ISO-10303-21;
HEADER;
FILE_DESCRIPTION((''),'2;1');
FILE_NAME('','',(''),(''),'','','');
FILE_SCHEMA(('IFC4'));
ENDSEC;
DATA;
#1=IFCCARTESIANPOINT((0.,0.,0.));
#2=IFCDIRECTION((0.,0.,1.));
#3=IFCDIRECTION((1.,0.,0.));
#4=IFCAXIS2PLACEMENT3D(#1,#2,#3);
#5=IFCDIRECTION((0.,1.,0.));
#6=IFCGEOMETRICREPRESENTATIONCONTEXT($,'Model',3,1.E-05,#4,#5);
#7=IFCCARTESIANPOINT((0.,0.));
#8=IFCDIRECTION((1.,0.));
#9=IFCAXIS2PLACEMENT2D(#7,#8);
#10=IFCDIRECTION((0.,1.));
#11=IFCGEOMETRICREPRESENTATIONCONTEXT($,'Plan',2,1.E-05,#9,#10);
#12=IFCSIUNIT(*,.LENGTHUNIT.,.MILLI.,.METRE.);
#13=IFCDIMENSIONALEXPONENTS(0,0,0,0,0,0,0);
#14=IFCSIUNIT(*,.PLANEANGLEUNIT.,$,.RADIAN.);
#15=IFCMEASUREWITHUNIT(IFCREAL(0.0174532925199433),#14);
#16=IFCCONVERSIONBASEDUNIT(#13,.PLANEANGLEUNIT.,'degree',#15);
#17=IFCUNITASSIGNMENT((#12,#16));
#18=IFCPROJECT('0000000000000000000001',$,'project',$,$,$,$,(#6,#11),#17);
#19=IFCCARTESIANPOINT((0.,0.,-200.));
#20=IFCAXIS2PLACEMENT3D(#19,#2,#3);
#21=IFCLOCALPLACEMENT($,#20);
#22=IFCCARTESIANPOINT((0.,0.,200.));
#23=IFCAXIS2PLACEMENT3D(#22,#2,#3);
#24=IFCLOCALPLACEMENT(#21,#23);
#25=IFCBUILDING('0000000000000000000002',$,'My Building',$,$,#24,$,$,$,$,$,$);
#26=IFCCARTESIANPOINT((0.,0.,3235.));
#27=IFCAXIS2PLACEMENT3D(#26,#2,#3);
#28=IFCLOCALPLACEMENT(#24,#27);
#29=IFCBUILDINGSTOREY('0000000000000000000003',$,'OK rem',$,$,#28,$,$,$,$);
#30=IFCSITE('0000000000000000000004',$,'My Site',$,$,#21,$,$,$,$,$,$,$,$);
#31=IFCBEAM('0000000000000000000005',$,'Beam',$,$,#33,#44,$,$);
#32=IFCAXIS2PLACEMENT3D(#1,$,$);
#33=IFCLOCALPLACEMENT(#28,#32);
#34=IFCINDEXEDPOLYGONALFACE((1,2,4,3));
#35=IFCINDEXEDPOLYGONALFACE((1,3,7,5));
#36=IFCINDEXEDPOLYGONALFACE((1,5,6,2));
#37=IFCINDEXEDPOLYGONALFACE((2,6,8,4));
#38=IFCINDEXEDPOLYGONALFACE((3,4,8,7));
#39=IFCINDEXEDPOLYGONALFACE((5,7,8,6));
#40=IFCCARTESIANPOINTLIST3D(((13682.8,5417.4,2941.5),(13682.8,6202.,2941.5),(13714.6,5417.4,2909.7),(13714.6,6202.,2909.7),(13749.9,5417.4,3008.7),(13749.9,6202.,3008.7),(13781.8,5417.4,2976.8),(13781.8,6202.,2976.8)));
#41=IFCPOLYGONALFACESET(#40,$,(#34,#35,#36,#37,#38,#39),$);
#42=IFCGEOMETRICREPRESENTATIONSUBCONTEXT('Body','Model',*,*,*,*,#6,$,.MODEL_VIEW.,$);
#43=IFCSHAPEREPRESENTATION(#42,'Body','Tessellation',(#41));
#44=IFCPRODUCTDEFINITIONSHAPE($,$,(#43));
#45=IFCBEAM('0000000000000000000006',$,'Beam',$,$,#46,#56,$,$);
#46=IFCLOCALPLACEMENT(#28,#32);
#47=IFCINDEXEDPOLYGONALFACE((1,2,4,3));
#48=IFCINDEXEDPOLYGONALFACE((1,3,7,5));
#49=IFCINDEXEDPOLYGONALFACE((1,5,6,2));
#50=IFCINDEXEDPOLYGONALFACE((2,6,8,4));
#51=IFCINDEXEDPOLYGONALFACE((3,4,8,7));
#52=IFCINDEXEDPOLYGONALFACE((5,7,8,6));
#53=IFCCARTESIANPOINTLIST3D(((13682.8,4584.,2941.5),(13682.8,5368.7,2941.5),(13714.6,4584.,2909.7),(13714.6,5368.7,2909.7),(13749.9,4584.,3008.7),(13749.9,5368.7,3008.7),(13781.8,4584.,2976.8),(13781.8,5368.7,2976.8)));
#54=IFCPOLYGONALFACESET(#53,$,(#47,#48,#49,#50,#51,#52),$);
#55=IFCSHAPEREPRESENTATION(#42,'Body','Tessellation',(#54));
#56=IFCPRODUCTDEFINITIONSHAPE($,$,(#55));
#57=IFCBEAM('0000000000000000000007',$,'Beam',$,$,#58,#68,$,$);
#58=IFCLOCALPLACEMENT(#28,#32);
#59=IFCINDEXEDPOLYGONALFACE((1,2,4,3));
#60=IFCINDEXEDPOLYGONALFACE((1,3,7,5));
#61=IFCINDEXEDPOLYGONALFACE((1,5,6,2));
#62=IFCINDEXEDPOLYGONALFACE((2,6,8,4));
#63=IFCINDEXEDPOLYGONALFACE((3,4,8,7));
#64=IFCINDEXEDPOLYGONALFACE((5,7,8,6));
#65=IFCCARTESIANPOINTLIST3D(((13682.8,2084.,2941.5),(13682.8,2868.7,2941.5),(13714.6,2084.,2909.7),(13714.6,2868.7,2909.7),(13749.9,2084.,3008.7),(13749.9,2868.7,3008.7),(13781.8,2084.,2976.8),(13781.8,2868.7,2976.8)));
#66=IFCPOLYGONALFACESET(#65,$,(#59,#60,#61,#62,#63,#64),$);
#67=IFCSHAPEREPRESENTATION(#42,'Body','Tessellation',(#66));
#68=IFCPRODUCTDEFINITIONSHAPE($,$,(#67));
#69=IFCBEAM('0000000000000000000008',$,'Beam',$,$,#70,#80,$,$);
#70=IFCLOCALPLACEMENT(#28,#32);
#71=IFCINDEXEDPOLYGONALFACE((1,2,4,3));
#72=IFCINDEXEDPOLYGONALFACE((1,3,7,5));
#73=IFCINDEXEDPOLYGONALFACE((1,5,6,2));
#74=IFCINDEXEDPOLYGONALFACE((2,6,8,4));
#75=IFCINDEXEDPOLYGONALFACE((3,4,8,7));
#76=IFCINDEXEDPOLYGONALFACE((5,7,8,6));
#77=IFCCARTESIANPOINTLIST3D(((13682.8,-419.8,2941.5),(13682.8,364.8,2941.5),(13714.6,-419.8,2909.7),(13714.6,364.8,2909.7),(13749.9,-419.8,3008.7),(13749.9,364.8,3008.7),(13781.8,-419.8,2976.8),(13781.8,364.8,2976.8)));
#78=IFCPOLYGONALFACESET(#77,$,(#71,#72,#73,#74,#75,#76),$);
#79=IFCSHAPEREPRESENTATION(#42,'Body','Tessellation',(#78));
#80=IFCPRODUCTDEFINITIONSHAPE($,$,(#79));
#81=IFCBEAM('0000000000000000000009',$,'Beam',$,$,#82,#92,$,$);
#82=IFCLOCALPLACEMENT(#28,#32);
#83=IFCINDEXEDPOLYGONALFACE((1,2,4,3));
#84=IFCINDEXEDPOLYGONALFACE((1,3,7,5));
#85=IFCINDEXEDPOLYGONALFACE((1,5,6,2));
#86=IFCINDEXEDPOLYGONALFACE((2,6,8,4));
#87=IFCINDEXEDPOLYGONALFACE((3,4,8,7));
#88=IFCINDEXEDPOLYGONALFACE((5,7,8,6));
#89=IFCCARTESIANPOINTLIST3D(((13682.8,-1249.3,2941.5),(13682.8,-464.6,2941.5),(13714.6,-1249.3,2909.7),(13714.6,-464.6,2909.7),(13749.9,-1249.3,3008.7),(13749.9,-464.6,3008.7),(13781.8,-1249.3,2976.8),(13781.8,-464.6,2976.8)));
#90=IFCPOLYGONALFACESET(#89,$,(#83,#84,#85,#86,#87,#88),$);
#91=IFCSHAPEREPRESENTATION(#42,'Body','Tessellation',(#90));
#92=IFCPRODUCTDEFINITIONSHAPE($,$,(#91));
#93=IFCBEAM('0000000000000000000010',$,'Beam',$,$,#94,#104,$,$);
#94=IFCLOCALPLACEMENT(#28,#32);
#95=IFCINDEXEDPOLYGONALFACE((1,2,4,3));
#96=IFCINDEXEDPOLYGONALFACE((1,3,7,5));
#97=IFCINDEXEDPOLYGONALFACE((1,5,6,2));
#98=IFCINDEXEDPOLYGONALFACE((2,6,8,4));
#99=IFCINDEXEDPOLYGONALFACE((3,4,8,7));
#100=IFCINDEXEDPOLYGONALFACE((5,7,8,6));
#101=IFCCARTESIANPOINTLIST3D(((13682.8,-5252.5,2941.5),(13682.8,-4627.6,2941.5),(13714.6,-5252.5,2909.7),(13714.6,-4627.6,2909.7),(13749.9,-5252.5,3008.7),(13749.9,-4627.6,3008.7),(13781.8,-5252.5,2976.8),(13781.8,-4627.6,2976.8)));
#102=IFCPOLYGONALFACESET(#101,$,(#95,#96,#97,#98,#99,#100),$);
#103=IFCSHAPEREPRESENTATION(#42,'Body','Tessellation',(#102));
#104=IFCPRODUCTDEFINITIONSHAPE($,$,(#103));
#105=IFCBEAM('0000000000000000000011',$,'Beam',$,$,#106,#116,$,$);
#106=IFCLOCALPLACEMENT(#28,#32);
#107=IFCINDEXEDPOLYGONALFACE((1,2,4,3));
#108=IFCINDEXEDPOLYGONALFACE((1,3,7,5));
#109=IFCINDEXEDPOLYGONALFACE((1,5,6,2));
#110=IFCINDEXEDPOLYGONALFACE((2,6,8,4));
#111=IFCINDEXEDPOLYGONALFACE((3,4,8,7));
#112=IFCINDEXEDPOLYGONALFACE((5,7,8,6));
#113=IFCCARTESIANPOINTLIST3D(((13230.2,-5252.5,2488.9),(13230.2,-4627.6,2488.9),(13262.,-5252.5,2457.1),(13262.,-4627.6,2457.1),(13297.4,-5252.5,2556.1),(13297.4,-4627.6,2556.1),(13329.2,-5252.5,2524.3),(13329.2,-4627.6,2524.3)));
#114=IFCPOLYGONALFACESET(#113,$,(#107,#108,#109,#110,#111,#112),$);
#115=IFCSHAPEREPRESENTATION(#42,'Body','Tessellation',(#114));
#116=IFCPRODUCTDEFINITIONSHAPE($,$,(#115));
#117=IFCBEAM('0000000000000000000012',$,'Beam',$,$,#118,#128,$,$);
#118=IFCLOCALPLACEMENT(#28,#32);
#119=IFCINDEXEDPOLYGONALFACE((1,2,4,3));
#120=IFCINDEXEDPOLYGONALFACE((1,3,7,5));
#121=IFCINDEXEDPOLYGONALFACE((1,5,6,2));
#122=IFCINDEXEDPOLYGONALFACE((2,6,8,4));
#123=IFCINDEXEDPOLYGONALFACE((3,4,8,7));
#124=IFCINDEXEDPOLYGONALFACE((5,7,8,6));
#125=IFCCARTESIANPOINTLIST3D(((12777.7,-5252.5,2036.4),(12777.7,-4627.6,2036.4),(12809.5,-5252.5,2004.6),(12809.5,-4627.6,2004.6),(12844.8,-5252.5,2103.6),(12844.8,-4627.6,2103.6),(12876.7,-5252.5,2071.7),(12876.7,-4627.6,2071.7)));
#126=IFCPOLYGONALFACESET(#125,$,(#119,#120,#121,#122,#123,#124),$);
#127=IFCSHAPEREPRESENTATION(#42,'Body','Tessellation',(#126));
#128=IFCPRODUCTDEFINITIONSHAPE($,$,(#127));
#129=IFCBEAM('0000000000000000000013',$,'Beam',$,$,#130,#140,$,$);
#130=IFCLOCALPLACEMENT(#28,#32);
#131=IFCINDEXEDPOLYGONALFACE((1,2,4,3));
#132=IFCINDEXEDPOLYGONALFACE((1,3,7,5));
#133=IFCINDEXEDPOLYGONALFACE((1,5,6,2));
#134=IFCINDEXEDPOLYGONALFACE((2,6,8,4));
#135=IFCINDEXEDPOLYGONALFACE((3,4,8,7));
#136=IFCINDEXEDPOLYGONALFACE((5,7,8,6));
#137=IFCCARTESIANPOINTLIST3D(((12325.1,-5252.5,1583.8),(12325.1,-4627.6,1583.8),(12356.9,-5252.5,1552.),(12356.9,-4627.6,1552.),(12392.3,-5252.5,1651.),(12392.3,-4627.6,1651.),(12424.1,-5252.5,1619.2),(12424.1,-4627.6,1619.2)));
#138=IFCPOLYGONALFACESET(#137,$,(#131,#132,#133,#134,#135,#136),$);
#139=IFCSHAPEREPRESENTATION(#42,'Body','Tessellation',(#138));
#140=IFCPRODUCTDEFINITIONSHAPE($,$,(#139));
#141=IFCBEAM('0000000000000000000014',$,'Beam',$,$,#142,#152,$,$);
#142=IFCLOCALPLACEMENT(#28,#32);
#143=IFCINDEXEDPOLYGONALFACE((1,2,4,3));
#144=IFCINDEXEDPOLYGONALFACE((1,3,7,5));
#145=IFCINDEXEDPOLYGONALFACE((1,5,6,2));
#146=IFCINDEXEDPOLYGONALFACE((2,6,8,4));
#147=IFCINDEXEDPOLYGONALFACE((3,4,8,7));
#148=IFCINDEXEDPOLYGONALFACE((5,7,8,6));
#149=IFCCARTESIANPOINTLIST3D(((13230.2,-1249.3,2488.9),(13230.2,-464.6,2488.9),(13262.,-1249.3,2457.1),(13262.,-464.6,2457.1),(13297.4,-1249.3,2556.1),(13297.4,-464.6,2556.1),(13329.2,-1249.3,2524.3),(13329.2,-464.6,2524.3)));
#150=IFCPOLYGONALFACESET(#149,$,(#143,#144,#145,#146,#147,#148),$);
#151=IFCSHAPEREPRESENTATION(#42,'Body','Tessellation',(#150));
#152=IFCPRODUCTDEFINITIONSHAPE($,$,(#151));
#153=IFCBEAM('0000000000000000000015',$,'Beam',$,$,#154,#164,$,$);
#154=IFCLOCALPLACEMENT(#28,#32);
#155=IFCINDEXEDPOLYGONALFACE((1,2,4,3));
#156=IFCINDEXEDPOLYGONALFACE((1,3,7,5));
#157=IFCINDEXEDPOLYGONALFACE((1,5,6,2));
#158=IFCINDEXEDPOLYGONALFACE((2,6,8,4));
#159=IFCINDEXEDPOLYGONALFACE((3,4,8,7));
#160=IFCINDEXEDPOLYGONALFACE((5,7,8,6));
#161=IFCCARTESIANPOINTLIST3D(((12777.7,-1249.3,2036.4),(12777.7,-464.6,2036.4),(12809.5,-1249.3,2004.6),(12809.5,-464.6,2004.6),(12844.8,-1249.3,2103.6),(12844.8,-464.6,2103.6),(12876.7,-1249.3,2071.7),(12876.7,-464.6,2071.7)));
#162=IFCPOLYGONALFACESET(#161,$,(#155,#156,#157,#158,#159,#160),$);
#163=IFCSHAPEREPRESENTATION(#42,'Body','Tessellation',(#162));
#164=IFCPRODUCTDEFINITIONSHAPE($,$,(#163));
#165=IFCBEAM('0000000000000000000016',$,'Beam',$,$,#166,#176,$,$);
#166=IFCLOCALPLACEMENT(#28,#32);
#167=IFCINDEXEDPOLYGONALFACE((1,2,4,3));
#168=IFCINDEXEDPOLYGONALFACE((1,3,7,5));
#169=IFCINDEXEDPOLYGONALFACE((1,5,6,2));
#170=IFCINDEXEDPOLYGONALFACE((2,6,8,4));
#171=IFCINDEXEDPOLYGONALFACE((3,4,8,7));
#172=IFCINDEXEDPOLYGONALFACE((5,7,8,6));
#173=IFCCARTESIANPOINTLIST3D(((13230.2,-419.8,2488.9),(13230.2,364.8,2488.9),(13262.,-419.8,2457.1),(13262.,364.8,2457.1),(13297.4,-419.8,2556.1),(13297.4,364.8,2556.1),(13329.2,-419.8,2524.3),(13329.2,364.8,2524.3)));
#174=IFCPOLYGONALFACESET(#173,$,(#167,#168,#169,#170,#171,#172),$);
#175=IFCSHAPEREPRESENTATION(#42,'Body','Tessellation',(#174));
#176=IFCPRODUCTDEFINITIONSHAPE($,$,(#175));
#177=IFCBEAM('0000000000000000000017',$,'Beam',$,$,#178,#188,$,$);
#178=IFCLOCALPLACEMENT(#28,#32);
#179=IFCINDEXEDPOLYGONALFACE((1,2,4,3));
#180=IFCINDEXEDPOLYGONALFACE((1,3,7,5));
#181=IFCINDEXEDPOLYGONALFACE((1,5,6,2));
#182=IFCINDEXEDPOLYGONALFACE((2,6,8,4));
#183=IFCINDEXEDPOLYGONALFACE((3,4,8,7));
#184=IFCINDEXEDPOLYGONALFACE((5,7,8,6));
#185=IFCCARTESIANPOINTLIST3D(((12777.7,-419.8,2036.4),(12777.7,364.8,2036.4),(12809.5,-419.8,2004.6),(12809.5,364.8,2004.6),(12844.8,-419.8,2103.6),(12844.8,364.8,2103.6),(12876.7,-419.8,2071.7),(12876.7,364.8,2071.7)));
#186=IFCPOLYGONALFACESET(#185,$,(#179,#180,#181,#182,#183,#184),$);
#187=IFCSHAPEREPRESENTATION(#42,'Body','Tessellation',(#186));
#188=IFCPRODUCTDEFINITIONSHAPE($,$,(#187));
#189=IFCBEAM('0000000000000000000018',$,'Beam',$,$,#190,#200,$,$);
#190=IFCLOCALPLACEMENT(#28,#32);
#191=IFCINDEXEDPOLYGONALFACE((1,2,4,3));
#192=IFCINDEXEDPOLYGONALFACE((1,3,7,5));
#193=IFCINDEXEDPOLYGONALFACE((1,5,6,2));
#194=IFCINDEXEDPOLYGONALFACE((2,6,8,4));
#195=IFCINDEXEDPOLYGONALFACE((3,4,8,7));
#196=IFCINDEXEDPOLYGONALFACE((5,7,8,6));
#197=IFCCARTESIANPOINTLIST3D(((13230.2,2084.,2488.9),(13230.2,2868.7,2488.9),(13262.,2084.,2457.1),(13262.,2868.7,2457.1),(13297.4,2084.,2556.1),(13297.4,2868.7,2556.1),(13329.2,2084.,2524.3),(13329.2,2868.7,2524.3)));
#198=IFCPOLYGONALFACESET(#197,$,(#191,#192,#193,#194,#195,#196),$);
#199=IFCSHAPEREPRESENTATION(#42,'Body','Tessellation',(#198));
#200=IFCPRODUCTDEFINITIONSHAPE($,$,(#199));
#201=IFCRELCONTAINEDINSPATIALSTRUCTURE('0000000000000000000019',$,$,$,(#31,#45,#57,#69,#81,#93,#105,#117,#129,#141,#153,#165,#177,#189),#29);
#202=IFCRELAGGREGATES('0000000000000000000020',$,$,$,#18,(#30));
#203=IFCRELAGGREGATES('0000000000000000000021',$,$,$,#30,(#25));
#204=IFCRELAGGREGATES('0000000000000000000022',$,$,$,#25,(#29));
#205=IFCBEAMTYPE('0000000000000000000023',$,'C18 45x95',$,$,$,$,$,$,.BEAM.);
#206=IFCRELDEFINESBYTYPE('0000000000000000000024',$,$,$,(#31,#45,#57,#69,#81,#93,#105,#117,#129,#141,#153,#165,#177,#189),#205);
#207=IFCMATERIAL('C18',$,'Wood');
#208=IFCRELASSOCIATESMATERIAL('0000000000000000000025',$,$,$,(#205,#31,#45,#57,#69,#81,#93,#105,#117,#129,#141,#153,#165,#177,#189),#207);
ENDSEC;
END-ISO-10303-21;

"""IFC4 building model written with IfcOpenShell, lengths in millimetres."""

from ifc_helpers import new_model, entity, si_unit, converted_unit, direction, frame, origin_with_axes, origin_2d_with_axis, place, context, subcontext, project, spatial, rectangle, extrude, material, material_profile, profile_set, profile_usage, type_object, element, save


model = new_model("IFC4")

# Units and contexts
model_context = context("Model", 3, precision=1e-05, world=origin_with_axes(), true_north=direction((0.0, 1.0, 0.0)))
plan_context = context("Plan", 2, precision=1e-05, world=origin_2d_with_axis(), true_north=direction((0.0, 1.0)))
body_context = subcontext(model_context, "Body", "Model", "MODEL_VIEW")
ifc_project = project(units=[si_unit("LENGTHUNIT", "METRE", prefix="MILLI"), converted_unit("PLANEANGLEUNIT", "degree", entity("IfcReal", 0.0174532925199433), si_unit("PLANEANGLEUNIT", "RADIAN"), dimensions=[0, 0, 0, 0, 0, 0, 0])], contexts=[model_context, plan_context])

# Site, building, storey
site_placement = place(None, frame((0.0, 0.0, -200.0), z_axis=(0.0, 0.0, 1.0), x_axis=(1.0, 0.0, 0.0)))
site = spatial("IfcSite", under=ifc_project, at=site_placement, Name="My Site")
building_placement = place(site_placement, frame((0.0, 0.0, 200.0), z_axis=(0.0, 0.0, 1.0), x_axis=(1.0, 0.0, 0.0)))
building = spatial("IfcBuilding", under=site, at=building_placement, Name="My Building")
storey_placement = place(building_placement, frame((0.0, 0.0, 3235.0), z_axis=(0.0, 0.0, 1.0), x_axis=(1.0, 0.0, 0.0)))
storey = spatial("IfcBuildingStorey", under=building, at=storey_placement, Name="OK rem")

# Beams
ifc_material = material(Name="C18", Category="Wood")
ifc_material_profile = material_profile(ifc_material, rectangle(XDim=45.0, YDim=95.0))
ifc_profile_set = profile_set([ifc_material_profile], Name="woodStructural")
ifc_profile_usage_1 = profile_usage(ifc_profile_set, cardinal=5)
beam_type = type_object("IfcBeamType", Name="C18 45x95", PredefinedType="BEAM", material=ifc_profile_set)
beam_1_placement = place(storey_placement, frame((13732.3, 5417.4, 2959.2), z_axis=(0.0, 1.0, 0.0), x_axis=(-0.707107, 0.0, 0.707107)))
element("IfcBeam", 1, at=beam_1_placement, inside=storey, type_object=beam_type, material=ifc_profile_usage_1, Name="Beam", context=body_context, shape_type="SweptSolid", body=[
    extrude(rectangle(XDim=45.0, YDim=95.0), origin_with_axes(), (0.0, 0.0, 1.0), 784.6),
])
ifc_profile_usage_2 = profile_usage(ifc_profile_set, cardinal=5)
beam_2_placement = place(storey_placement, frame((13732.3, 4584.0, 2959.2), z_axis=(0.0, 1.0, 0.0), x_axis=(-0.707107, 0.0, 0.707107)))
element("IfcBeam", 2, at=beam_2_placement, inside=storey, type_object=beam_type, material=ifc_profile_usage_2, Name="Beam", context=body_context, shape_type="SweptSolid", body=[
    extrude(rectangle(XDim=45.0, YDim=95.0), origin_with_axes(), (0.0, 0.0, 1.0), 784.6),
])
ifc_profile_usage_3 = profile_usage(ifc_profile_set, cardinal=5)
beam_3_placement = place(storey_placement, frame((13732.3, 2084.0, 2959.2), z_axis=(0.0, 1.0, 0.0), x_axis=(-0.707107, 0.0, 0.707107)))
element("IfcBeam", 3, at=beam_3_placement, inside=storey, type_object=beam_type, material=ifc_profile_usage_3, Name="Beam", context=body_context, shape_type="SweptSolid", body=[
    extrude(rectangle(XDim=45.0, YDim=95.0), origin_with_axes(), (0.0, 0.0, 1.0), 784.6),
])
ifc_profile_usage_4 = profile_usage(ifc_profile_set, cardinal=5)
beam_4_placement = place(storey_placement, frame((13732.3, -419.8, 2959.2), z_axis=(0.0, 1.0, 0.0), x_axis=(-0.707107, 0.0, 0.707107)))
element("IfcBeam", 4, at=beam_4_placement, inside=storey, type_object=beam_type, material=ifc_profile_usage_4, Name="Beam", context=body_context, shape_type="SweptSolid", body=[
    extrude(rectangle(XDim=45.0, YDim=95.0), origin_with_axes(), (0.0, 0.0, 1.0), 784.6),
])
ifc_profile_usage_5 = profile_usage(ifc_profile_set, cardinal=5)
beam_5_placement = place(storey_placement, frame((13732.3, -1249.3, 2959.2), z_axis=(0.0, 1.0, 0.0), x_axis=(-0.707107, 0.0, 0.707107)))
element("IfcBeam", 5, at=beam_5_placement, inside=storey, type_object=beam_type, material=ifc_profile_usage_5, Name="Beam", context=body_context, shape_type="SweptSolid", body=[
    extrude(rectangle(XDim=45.0, YDim=95.0), origin_with_axes(), (0.0, 0.0, 1.0), 784.6),
])
ifc_profile_usage_6 = profile_usage(ifc_profile_set, cardinal=5)
beam_6_placement = place(storey_placement, frame((13732.3, -5252.5, 2959.2), z_axis=(0.0, 1.0, 0.0), x_axis=(-0.707107, 0.0, 0.707107)))
element("IfcBeam", 6, at=beam_6_placement, inside=storey, type_object=beam_type, material=ifc_profile_usage_6, Name="Beam", context=body_context, shape_type="SweptSolid", body=[
    extrude(rectangle(XDim=45.0, YDim=95.0), origin_with_axes(), (0.0, 0.0, 1.0), 624.9),
])
ifc_profile_usage_7 = profile_usage(ifc_profile_set, cardinal=5)
beam_7_placement = place(storey_placement, frame((13279.7, -5252.5, 2506.6), z_axis=(0.0, 1.0, 0.0), x_axis=(-0.707107, 0.0, 0.707107)))
element("IfcBeam", 7, at=beam_7_placement, inside=storey, type_object=beam_type, material=ifc_profile_usage_7, Name="Beam", context=body_context, shape_type="SweptSolid", body=[
    extrude(rectangle(XDim=45.0, YDim=95.0), origin_with_axes(), (0.0, 0.0, 1.0), 624.9),
])
ifc_profile_usage_8 = profile_usage(ifc_profile_set, cardinal=5)
beam_8_placement = place(storey_placement, frame((12827.2, -5252.5, 2054.1), z_axis=(0.0, 1.0, 0.0), x_axis=(-0.707107, 0.0, 0.707107)))
element("IfcBeam", 8, at=beam_8_placement, inside=storey, type_object=beam_type, material=ifc_profile_usage_8, Name="Beam", context=body_context, shape_type="SweptSolid", body=[
    extrude(rectangle(XDim=45.0, YDim=95.0), origin_with_axes(), (0.0, 0.0, 1.0), 624.9),
])
ifc_profile_usage_9 = profile_usage(ifc_profile_set, cardinal=5)
beam_9_placement = place(storey_placement, frame((12374.6, -5252.5, 1601.5), z_axis=(0.0, 1.0, 0.0), x_axis=(-0.707107, 0.0, 0.707107)))
element("IfcBeam", 9, at=beam_9_placement, inside=storey, type_object=beam_type, material=ifc_profile_usage_9, Name="Beam", context=body_context, shape_type="SweptSolid", body=[
    extrude(rectangle(XDim=45.0, YDim=95.0), origin_with_axes(), (0.0, 0.0, 1.0), 624.9),
])
ifc_profile_usage_10 = profile_usage(ifc_profile_set, cardinal=5)
beam_10_placement = place(storey_placement, frame((13279.7, -1249.3, 2506.6), z_axis=(0.0, 1.0, 0.0), x_axis=(-0.707107, 0.0, 0.707107)))
element("IfcBeam", 10, at=beam_10_placement, inside=storey, type_object=beam_type, material=ifc_profile_usage_10, Name="Beam", context=body_context, shape_type="SweptSolid", body=[
    extrude(rectangle(XDim=45.0, YDim=95.0), origin_with_axes(), (0.0, 0.0, 1.0), 784.6),
])
ifc_profile_usage_11 = profile_usage(ifc_profile_set, cardinal=5)
beam_11_placement = place(storey_placement, frame((12827.2, -1249.3, 2054.1), z_axis=(0.0, 1.0, 0.0), x_axis=(-0.707107, 0.0, 0.707107)))
element("IfcBeam", 11, at=beam_11_placement, inside=storey, type_object=beam_type, material=ifc_profile_usage_11, Name="Beam", context=body_context, shape_type="SweptSolid", body=[
    extrude(rectangle(XDim=45.0, YDim=95.0), origin_with_axes(), (0.0, 0.0, 1.0), 784.6),
])
ifc_profile_usage_12 = profile_usage(ifc_profile_set, cardinal=5)
beam_12_placement = place(storey_placement, frame((13279.7, -419.8, 2506.6), z_axis=(0.0, 1.0, 0.0), x_axis=(-0.707107, 0.0, 0.707107)))
element("IfcBeam", 12, at=beam_12_placement, inside=storey, type_object=beam_type, material=ifc_profile_usage_12, Name="Beam", context=body_context, shape_type="SweptSolid", body=[
    extrude(rectangle(XDim=45.0, YDim=95.0), origin_with_axes(), (0.0, 0.0, 1.0), 784.6),
])
ifc_profile_usage_13 = profile_usage(ifc_profile_set, cardinal=5)
beam_13_placement = place(storey_placement, frame((12827.2, -419.8, 2054.1), z_axis=(0.0, 1.0, 0.0), x_axis=(-0.707107, 0.0, 0.707107)))
element("IfcBeam", 13, at=beam_13_placement, inside=storey, type_object=beam_type, material=ifc_profile_usage_13, Name="Beam", context=body_context, shape_type="SweptSolid", body=[
    extrude(rectangle(XDim=45.0, YDim=95.0), origin_with_axes(), (0.0, 0.0, 1.0), 784.6),
])
ifc_profile_usage_14 = profile_usage(ifc_profile_set, cardinal=5)
beam_14_placement = place(storey_placement, frame((13279.7, 2084.0, 2506.6), z_axis=(0.0, 1.0, 0.0), x_axis=(-0.707107, 0.0, 0.707107)))
element("IfcBeam", 14, at=beam_14_placement, inside=storey, type_object=beam_type, material=ifc_profile_usage_14, Name="Beam", context=body_context, shape_type="SweptSolid", body=[
    extrude(rectangle(XDim=45.0, YDim=95.0), origin_with_axes(), (0.0, 0.0, 1.0), 784.6),
])

save(model, "model.ifc")
